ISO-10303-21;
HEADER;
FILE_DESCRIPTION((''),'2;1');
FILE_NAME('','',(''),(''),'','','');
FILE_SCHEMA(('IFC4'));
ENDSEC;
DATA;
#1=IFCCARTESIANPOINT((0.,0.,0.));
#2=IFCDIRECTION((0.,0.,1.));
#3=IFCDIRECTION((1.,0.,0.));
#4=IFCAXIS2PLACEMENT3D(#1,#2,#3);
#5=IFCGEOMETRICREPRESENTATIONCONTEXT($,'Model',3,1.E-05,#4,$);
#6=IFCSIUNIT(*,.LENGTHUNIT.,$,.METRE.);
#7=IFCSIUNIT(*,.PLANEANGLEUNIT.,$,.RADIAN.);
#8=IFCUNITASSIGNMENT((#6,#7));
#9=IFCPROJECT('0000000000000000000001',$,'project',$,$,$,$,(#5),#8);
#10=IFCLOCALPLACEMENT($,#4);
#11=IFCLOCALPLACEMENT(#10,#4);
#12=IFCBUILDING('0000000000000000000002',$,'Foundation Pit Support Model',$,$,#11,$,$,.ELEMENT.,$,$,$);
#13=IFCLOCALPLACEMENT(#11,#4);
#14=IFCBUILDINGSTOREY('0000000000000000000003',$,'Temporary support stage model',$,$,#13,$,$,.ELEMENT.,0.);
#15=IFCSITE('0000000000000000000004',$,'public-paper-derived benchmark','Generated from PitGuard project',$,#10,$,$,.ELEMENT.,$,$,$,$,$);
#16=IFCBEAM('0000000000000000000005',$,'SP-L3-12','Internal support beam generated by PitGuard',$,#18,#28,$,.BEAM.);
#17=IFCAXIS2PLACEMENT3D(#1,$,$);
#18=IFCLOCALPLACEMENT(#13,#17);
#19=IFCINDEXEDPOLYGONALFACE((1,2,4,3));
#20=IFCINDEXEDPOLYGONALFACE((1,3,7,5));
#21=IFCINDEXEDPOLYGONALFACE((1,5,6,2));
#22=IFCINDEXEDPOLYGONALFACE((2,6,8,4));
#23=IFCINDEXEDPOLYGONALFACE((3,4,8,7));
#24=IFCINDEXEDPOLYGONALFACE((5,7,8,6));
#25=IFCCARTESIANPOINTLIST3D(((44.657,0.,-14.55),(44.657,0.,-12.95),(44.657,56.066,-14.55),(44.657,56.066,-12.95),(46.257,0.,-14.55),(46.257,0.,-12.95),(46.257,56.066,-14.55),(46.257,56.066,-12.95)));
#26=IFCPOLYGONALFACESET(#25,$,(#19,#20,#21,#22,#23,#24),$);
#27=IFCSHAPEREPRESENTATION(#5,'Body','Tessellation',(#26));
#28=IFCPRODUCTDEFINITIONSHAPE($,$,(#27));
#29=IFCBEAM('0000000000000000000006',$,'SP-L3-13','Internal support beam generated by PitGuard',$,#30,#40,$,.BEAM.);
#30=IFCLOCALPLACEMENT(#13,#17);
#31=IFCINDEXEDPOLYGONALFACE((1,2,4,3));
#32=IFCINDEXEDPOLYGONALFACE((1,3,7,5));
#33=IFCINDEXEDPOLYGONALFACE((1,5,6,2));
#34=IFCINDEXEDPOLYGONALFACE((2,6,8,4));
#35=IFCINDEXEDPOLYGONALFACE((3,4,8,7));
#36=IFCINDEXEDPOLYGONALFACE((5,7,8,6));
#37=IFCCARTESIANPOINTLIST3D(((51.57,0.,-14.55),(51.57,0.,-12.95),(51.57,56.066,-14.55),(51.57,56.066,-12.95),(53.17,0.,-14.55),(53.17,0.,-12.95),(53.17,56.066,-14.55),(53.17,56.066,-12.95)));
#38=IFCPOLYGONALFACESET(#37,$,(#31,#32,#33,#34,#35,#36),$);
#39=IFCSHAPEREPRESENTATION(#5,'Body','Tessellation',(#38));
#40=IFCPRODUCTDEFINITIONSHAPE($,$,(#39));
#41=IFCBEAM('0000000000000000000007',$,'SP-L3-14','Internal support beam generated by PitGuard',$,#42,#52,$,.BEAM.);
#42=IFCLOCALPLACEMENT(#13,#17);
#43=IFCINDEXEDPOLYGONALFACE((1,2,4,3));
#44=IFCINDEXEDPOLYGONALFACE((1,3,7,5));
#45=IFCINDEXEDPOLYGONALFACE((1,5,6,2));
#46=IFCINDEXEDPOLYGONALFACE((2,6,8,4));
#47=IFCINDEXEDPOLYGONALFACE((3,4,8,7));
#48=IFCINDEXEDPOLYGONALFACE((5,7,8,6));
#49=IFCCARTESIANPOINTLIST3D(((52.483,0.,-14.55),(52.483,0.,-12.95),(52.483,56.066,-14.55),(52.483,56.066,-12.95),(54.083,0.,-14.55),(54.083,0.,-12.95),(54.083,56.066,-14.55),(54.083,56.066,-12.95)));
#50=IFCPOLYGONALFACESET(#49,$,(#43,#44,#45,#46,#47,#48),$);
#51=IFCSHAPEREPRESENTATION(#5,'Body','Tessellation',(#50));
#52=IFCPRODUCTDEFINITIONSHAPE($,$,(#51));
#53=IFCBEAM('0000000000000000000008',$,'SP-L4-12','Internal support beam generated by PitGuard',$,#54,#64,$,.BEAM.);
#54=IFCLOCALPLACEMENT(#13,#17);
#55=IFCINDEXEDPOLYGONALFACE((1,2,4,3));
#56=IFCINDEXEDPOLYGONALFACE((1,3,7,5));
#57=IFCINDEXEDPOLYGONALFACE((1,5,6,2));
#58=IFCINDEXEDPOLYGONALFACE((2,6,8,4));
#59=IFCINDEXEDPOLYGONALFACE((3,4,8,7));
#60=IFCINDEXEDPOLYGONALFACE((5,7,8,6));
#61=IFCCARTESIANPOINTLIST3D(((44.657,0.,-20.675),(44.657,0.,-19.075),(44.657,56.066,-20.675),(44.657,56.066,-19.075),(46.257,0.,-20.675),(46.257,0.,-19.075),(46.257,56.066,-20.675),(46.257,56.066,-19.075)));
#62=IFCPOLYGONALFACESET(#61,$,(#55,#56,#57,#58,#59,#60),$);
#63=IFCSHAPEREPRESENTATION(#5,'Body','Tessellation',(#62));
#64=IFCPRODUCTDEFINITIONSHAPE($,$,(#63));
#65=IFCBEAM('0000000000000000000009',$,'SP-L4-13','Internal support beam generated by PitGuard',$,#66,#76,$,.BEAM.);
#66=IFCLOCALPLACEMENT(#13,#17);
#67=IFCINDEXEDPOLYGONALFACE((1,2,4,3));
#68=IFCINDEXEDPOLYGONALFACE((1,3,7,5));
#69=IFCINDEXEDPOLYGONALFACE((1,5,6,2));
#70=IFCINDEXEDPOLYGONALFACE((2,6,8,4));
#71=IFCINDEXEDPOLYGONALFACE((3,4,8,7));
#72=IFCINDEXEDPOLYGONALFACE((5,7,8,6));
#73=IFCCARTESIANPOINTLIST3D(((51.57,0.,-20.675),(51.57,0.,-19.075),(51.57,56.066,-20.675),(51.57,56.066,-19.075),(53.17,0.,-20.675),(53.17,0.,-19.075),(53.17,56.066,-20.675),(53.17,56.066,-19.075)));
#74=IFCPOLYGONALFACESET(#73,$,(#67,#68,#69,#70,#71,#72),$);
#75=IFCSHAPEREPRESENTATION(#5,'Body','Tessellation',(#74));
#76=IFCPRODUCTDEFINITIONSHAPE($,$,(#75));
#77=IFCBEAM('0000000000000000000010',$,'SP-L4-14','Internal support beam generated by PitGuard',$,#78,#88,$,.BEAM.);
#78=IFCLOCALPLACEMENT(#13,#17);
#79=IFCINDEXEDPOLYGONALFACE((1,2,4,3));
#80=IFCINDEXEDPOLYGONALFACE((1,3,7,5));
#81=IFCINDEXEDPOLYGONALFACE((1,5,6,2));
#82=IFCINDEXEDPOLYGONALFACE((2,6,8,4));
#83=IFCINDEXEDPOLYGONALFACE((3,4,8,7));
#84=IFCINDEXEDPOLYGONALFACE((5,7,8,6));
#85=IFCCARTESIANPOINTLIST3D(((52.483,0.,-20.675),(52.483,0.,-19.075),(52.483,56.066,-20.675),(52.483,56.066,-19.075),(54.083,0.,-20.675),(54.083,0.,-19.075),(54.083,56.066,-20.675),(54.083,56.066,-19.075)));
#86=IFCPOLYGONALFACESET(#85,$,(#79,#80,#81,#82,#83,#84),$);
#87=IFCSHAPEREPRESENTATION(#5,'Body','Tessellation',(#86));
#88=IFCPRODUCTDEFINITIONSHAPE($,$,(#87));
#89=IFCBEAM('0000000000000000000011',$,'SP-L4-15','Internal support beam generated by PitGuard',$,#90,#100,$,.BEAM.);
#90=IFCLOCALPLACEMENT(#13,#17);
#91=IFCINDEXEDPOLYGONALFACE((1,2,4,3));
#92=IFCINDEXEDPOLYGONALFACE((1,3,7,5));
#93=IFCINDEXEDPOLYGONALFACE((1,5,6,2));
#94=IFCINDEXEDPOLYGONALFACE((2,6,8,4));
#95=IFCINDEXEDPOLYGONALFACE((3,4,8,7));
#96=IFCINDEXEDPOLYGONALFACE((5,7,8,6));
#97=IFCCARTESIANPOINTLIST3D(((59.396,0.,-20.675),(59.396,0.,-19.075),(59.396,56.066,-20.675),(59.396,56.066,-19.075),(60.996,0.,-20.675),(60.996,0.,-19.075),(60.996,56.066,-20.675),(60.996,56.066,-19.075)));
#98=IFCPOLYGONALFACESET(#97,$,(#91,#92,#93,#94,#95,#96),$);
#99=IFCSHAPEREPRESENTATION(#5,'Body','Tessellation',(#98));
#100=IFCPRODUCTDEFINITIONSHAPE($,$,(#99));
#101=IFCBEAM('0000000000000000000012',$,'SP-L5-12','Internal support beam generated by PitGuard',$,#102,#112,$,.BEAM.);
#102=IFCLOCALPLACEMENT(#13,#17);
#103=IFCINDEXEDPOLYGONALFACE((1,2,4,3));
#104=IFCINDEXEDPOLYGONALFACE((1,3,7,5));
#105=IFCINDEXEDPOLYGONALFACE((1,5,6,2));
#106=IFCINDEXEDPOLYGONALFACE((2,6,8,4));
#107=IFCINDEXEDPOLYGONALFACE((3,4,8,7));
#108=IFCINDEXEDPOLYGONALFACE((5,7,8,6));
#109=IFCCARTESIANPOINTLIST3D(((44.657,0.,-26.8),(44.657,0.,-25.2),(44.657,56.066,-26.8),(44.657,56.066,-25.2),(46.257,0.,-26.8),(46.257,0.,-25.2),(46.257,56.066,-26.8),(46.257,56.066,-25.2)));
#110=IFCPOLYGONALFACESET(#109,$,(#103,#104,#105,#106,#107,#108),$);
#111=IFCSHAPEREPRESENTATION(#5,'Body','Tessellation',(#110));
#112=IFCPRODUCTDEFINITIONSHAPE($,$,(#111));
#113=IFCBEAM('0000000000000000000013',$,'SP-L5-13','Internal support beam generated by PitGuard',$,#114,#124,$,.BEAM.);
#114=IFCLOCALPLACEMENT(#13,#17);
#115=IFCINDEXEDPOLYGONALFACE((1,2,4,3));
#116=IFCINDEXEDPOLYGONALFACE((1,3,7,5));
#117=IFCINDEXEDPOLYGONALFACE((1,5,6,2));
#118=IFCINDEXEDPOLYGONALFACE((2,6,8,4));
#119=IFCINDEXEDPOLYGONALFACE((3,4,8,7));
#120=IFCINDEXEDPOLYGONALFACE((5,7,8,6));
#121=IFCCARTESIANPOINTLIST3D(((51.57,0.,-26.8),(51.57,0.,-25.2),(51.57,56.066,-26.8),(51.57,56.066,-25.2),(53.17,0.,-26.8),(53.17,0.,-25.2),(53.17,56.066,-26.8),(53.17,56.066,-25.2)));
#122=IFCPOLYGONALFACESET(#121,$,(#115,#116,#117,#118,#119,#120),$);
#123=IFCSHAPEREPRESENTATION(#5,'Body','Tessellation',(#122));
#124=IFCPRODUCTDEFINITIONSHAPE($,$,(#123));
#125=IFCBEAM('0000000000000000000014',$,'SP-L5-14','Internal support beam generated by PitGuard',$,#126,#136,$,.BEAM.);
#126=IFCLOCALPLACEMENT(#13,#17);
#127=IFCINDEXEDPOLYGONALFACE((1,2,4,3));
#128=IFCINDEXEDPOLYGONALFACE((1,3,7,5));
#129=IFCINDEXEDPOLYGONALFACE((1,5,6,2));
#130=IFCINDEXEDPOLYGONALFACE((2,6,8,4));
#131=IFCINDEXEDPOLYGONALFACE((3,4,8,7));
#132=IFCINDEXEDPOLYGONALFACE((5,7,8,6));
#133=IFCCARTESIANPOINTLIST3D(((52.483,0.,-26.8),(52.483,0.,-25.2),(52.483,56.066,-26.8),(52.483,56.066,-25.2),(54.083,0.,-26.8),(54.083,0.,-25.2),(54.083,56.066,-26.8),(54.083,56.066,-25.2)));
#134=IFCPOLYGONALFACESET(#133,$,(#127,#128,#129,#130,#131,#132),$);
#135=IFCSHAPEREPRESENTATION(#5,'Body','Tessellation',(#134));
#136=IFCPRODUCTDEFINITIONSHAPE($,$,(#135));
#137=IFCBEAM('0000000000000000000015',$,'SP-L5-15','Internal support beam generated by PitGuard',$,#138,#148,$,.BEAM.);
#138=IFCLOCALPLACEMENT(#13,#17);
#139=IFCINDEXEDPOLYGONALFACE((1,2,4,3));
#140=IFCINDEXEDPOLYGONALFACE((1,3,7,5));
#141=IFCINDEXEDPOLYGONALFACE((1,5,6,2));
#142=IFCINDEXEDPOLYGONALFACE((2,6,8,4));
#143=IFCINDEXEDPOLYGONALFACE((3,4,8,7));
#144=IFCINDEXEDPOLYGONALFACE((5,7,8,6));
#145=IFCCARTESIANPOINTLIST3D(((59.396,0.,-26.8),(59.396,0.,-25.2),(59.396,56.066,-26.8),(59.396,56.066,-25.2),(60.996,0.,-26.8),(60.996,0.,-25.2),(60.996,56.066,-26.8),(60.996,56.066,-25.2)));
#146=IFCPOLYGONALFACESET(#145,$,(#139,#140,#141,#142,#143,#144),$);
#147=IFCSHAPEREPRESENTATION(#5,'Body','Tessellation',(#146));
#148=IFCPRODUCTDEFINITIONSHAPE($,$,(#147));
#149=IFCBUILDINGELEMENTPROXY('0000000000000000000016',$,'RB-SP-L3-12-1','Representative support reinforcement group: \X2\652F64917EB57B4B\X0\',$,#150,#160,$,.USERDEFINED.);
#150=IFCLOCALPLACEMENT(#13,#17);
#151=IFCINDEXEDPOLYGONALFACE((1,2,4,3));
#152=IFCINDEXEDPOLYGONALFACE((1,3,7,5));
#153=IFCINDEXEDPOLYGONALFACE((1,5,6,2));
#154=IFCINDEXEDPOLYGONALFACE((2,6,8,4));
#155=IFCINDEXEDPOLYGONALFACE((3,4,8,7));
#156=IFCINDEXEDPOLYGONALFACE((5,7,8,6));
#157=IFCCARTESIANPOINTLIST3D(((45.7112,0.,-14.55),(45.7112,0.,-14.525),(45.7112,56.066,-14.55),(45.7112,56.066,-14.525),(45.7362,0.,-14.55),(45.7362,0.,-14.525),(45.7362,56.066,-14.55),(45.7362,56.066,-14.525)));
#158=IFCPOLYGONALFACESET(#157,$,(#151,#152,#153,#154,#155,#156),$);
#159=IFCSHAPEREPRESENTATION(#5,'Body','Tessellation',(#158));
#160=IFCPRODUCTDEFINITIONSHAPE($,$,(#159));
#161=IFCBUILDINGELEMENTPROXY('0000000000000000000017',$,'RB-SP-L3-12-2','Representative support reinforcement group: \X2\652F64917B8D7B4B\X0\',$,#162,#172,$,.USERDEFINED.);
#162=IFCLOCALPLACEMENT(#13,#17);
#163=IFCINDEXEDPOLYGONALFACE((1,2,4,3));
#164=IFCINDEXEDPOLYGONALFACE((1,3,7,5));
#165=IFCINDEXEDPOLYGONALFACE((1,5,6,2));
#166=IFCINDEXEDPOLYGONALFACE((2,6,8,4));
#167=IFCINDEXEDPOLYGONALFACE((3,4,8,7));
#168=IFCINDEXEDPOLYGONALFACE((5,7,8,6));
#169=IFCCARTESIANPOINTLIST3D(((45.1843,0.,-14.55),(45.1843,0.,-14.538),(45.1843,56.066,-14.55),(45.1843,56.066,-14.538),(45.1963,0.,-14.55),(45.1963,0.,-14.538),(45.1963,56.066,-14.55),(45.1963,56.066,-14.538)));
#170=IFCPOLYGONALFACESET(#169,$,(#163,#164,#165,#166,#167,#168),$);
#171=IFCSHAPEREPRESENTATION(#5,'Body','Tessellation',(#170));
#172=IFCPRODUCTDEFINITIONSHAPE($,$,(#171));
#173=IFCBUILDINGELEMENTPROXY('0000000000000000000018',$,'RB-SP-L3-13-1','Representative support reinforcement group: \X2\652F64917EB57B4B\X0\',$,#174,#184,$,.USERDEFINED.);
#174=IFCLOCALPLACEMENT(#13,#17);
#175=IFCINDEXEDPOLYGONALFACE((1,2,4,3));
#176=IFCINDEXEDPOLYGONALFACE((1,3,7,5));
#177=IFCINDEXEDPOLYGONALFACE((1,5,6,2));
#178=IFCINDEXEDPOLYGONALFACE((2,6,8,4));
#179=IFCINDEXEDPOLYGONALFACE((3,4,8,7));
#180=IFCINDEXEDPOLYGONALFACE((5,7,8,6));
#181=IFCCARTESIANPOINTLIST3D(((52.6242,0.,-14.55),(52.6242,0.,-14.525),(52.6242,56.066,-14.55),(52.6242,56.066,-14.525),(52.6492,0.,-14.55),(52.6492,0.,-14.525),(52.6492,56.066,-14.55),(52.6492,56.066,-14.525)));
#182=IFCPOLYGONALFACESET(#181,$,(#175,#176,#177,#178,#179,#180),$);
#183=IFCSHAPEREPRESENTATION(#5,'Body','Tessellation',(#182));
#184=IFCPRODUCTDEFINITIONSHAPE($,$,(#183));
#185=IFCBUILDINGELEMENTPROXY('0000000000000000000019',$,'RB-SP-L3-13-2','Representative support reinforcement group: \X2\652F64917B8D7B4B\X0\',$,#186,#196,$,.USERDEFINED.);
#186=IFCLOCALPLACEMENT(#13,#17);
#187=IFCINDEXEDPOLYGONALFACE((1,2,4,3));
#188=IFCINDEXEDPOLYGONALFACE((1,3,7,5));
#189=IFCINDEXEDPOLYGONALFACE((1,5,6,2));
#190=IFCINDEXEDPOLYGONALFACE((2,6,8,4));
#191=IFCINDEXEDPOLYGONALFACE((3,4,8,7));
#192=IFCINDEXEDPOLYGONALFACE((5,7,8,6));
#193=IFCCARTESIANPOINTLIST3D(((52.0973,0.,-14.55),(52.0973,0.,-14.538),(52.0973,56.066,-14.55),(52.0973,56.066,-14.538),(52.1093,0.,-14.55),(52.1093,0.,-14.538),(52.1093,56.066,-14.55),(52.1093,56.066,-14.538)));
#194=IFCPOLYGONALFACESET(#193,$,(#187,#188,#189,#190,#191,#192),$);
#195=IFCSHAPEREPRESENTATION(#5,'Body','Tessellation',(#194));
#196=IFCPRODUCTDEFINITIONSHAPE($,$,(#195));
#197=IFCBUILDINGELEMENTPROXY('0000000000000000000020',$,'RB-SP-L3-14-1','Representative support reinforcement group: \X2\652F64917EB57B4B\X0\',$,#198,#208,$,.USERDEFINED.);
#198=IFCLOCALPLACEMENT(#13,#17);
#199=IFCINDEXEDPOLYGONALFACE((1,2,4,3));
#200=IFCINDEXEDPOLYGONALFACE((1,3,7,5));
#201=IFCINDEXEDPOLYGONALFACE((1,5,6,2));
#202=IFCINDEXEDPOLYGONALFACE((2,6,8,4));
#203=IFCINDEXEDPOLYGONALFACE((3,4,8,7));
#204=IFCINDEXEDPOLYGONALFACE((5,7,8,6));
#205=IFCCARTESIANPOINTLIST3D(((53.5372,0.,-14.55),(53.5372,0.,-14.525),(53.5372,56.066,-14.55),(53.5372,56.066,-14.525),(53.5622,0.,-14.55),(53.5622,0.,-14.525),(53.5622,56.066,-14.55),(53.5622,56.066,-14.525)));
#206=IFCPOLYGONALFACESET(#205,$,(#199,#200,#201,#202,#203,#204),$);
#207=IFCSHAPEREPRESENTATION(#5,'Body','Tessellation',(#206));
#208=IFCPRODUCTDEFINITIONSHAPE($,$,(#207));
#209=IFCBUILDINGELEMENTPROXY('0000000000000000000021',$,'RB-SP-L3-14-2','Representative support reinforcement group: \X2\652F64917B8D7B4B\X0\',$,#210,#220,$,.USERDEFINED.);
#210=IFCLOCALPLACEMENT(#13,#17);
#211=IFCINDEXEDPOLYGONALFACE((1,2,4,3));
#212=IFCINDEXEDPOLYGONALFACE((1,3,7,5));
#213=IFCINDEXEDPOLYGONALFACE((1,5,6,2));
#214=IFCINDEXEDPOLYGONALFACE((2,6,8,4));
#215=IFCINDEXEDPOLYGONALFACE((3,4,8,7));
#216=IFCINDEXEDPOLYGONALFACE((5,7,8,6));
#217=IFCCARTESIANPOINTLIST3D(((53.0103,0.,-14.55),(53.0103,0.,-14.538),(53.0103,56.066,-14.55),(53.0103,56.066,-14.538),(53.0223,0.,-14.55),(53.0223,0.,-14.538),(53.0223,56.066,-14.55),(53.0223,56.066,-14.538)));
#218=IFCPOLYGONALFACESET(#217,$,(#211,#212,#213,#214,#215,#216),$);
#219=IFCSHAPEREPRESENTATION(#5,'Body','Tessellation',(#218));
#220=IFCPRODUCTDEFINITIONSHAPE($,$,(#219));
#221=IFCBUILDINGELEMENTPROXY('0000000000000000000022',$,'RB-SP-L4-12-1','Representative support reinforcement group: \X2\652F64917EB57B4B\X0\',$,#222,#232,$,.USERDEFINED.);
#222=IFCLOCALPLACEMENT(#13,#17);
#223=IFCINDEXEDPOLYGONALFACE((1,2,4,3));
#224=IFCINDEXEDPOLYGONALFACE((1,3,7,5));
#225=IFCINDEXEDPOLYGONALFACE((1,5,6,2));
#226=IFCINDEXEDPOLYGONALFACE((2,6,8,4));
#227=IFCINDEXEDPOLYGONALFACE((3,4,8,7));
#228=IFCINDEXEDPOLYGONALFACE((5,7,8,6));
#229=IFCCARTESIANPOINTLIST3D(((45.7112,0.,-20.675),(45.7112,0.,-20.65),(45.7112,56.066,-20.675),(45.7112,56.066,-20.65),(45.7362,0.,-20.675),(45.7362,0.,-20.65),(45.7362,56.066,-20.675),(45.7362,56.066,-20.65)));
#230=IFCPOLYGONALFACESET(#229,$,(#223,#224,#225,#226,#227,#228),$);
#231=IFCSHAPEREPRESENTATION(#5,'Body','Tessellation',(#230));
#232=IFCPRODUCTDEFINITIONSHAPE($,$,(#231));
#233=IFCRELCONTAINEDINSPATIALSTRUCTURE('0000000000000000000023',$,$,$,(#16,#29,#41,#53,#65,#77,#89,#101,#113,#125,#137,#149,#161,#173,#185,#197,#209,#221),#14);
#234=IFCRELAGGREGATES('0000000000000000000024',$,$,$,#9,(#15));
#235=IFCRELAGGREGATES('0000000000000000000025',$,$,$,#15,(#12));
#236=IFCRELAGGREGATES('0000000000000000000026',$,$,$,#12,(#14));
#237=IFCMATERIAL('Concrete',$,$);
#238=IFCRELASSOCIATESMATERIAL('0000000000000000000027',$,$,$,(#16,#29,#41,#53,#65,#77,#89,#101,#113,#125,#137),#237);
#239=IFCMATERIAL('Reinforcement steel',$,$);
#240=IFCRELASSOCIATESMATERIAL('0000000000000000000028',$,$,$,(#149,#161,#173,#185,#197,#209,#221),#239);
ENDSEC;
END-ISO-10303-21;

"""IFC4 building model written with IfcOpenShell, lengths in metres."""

from ifc_helpers import new_model, si_unit, frame, origin_with_axes, origin_2d, place, context, project, spatial, rectangle, extrude, material, element, save


model = new_model("IFC4")

# Units and contexts
model_context = context("Model", 3, precision=1e-05, world=origin_with_axes())
ifc_project = project(units=[si_unit("LENGTHUNIT", "METRE"), si_unit("PLANEANGLEUNIT", "RADIAN")], contexts=[model_context])

# Site, building, storey
site_placement = place(None, origin_with_axes())
site = spatial("IfcSite", under=ifc_project, at=site_placement, Name="public-paper-derived benchmark", Description="Generated from PitGuard project", CompositionType="ELEMENT")
building_placement = place(site_placement, origin_with_axes())
building = spatial("IfcBuilding", under=site, at=building_placement, Name="Foundation Pit Support Model", CompositionType="ELEMENT")
storey_placement = place(building_placement, origin_with_axes())
storey = spatial("IfcBuildingStorey", under=building, at=storey_placement, Name="Temporary support stage model", CompositionType="ELEMENT", Elevation=0.0)

# Beams
ifc_material_1 = material(Name="Concrete")
for number, where, z_axis, x_axis, name in (
    (1, (45.457, 28.033, -14.55), (0.0, 0.0, 1.0), (0.0, 1.0, 0.0), "SP-L3-12"),
    (2, (52.37, 28.033, -14.55), (0.0, 0.0, 1.0), (0.0, 1.0, 0.0), "SP-L3-13"),
    (3, (53.283, 28.033, -14.55), (0.0, 0.0, 1.0), (0.0, 1.0, 0.0), "SP-L3-14"),
    (4, (45.457, 28.033, -20.675), (0.0, 0.0, 1.0), (0.0, 1.0, 0.0), "SP-L4-12"),
    (5, (52.37, 28.033, -20.675), (0.0, 0.0, 1.0), (0.0, 1.0, 0.0), "SP-L4-13"),
    (6, (53.283, 28.033, -20.675), (0.0, 0.0, 1.0), (0.0, 1.0, 0.0), "SP-L4-14"),
    (7, (60.196, 28.033, -20.675), (0.0, 0.0, 1.0), (0.0, 1.0, 0.0), "SP-L4-15"),
    (8, (45.457, 28.033, -26.8), (0.0, 0.0, 1.0), (0.0, 1.0, 0.0), "SP-L5-12"),
    (9, (52.37, 28.033, -26.8), (0.0, 0.0, 1.0), (0.0, 1.0, 0.0), "SP-L5-13"),
    (10, (53.283, 28.033, -26.8), (0.0, 0.0, 1.0), (0.0, 1.0, 0.0), "SP-L5-14"),
    (11, (60.196, 28.033, -26.8), (0.0, 0.0, 1.0), (0.0, 1.0, 0.0), "SP-L5-15"),
):
    element("IfcBeam", number, at=place(storey_placement, frame(where, z_axis=z_axis, x_axis=x_axis)), inside=storey, material=ifc_material_1, Name=name, Description="Internal support beam generated by PitGuard", PredefinedType="BEAM", context=model_context, shape_type="SweptSolid", body=[
        extrude(rectangle(XDim=56.066, YDim=1.6, at=origin_2d()), origin_with_axes(), (0.0, 0.0, 1.0), 1.6),
    ])

# Building element proxies
ifc_material_2 = material(Name="Reinforcement steel")
proxy_1_placement = place(storey_placement, frame((45.7237, 28.033, -14.55), z_axis=(0.0, 0.0, 1.0), x_axis=(0.0, 1.0, 0.0)))
element("IfcBuildingElementProxy", 12, at=proxy_1_placement, inside=storey, material=ifc_material_2, Name="RB-SP-L3-12-1", Description="Representative support reinforcement group: 支撑纵筋", PredefinedType="USERDEFINED", context=model_context, shape_type="SweptSolid", body=[
    extrude(rectangle(XDim=56.066, YDim=0.025, at=origin_2d()), origin_with_axes(), (0.0, 0.0, 1.0), 0.025),
])
proxy_2_placement = place(storey_placement, frame((45.1903, 28.033, -14.55), z_axis=(0.0, 0.0, 1.0), x_axis=(0.0, 1.0, 0.0)))
element("IfcBuildingElementProxy", 13, at=proxy_2_placement, inside=storey, material=ifc_material_2, Name="RB-SP-L3-12-2", Description="Representative support reinforcement group: 支撑箍筋", PredefinedType="USERDEFINED", context=model_context, shape_type="SweptSolid", body=[
    extrude(rectangle(XDim=56.066, YDim=0.012, at=origin_2d()), origin_with_axes(), (0.0, 0.0, 1.0), 0.012),
])
proxy_3_placement = place(storey_placement, frame((52.6367, 28.033, -14.55), z_axis=(0.0, 0.0, 1.0), x_axis=(0.0, 1.0, 0.0)))
element("IfcBuildingElementProxy", 14, at=proxy_3_placement, inside=storey, material=ifc_material_2, Name="RB-SP-L3-13-1", Description="Representative support reinforcement group: 支撑纵筋", PredefinedType="USERDEFINED", context=model_context, shape_type="SweptSolid", body=[
    extrude(rectangle(XDim=56.066, YDim=0.025, at=origin_2d()), origin_with_axes(), (0.0, 0.0, 1.0), 0.025),
])
proxy_4_placement = place(storey_placement, frame((52.1033, 28.033, -14.55), z_axis=(0.0, 0.0, 1.0), x_axis=(0.0, 1.0, 0.0)))
element("IfcBuildingElementProxy", 15, at=proxy_4_placement, inside=storey, material=ifc_material_2, Name="RB-SP-L3-13-2", Description="Representative support reinforcement group: 支撑箍筋", PredefinedType="USERDEFINED", context=model_context, shape_type="SweptSolid", body=[
    extrude(rectangle(XDim=56.066, YDim=0.012, at=origin_2d()), origin_with_axes(), (0.0, 0.0, 1.0), 0.012),
])
proxy_5_placement = place(storey_placement, frame((53.5497, 28.033, -14.55), z_axis=(0.0, 0.0, 1.0), x_axis=(0.0, 1.0, 0.0)))
element("IfcBuildingElementProxy", 16, at=proxy_5_placement, inside=storey, material=ifc_material_2, Name="RB-SP-L3-14-1", Description="Representative support reinforcement group: 支撑纵筋", PredefinedType="USERDEFINED", context=model_context, shape_type="SweptSolid", body=[
    extrude(rectangle(XDim=56.066, YDim=0.025, at=origin_2d()), origin_with_axes(), (0.0, 0.0, 1.0), 0.025),
])
proxy_6_placement = place(storey_placement, frame((53.0163, 28.033, -14.55), z_axis=(0.0, 0.0, 1.0), x_axis=(0.0, 1.0, 0.0)))
element("IfcBuildingElementProxy", 17, at=proxy_6_placement, inside=storey, material=ifc_material_2, Name="RB-SP-L3-14-2", Description="Representative support reinforcement group: 支撑箍筋", PredefinedType="USERDEFINED", context=model_context, shape_type="SweptSolid", body=[
    extrude(rectangle(XDim=56.066, YDim=0.012, at=origin_2d()), origin_with_axes(), (0.0, 0.0, 1.0), 0.012),
])
proxy_7_placement = place(storey_placement, frame((45.7237, 28.033, -20.675), z_axis=(0.0, 0.0, 1.0), x_axis=(0.0, 1.0, 0.0)))
element("IfcBuildingElementProxy", 18, at=proxy_7_placement, inside=storey, material=ifc_material_2, Name="RB-SP-L4-12-1", Description="Representative support reinforcement group: 支撑纵筋", PredefinedType="USERDEFINED", context=model_context, shape_type="SweptSolid", body=[
    extrude(rectangle(XDim=56.066, YDim=0.025, at=origin_2d()), origin_with_axes(), (0.0, 0.0, 1.0), 0.025),
])

save(model, "model.ifc")
